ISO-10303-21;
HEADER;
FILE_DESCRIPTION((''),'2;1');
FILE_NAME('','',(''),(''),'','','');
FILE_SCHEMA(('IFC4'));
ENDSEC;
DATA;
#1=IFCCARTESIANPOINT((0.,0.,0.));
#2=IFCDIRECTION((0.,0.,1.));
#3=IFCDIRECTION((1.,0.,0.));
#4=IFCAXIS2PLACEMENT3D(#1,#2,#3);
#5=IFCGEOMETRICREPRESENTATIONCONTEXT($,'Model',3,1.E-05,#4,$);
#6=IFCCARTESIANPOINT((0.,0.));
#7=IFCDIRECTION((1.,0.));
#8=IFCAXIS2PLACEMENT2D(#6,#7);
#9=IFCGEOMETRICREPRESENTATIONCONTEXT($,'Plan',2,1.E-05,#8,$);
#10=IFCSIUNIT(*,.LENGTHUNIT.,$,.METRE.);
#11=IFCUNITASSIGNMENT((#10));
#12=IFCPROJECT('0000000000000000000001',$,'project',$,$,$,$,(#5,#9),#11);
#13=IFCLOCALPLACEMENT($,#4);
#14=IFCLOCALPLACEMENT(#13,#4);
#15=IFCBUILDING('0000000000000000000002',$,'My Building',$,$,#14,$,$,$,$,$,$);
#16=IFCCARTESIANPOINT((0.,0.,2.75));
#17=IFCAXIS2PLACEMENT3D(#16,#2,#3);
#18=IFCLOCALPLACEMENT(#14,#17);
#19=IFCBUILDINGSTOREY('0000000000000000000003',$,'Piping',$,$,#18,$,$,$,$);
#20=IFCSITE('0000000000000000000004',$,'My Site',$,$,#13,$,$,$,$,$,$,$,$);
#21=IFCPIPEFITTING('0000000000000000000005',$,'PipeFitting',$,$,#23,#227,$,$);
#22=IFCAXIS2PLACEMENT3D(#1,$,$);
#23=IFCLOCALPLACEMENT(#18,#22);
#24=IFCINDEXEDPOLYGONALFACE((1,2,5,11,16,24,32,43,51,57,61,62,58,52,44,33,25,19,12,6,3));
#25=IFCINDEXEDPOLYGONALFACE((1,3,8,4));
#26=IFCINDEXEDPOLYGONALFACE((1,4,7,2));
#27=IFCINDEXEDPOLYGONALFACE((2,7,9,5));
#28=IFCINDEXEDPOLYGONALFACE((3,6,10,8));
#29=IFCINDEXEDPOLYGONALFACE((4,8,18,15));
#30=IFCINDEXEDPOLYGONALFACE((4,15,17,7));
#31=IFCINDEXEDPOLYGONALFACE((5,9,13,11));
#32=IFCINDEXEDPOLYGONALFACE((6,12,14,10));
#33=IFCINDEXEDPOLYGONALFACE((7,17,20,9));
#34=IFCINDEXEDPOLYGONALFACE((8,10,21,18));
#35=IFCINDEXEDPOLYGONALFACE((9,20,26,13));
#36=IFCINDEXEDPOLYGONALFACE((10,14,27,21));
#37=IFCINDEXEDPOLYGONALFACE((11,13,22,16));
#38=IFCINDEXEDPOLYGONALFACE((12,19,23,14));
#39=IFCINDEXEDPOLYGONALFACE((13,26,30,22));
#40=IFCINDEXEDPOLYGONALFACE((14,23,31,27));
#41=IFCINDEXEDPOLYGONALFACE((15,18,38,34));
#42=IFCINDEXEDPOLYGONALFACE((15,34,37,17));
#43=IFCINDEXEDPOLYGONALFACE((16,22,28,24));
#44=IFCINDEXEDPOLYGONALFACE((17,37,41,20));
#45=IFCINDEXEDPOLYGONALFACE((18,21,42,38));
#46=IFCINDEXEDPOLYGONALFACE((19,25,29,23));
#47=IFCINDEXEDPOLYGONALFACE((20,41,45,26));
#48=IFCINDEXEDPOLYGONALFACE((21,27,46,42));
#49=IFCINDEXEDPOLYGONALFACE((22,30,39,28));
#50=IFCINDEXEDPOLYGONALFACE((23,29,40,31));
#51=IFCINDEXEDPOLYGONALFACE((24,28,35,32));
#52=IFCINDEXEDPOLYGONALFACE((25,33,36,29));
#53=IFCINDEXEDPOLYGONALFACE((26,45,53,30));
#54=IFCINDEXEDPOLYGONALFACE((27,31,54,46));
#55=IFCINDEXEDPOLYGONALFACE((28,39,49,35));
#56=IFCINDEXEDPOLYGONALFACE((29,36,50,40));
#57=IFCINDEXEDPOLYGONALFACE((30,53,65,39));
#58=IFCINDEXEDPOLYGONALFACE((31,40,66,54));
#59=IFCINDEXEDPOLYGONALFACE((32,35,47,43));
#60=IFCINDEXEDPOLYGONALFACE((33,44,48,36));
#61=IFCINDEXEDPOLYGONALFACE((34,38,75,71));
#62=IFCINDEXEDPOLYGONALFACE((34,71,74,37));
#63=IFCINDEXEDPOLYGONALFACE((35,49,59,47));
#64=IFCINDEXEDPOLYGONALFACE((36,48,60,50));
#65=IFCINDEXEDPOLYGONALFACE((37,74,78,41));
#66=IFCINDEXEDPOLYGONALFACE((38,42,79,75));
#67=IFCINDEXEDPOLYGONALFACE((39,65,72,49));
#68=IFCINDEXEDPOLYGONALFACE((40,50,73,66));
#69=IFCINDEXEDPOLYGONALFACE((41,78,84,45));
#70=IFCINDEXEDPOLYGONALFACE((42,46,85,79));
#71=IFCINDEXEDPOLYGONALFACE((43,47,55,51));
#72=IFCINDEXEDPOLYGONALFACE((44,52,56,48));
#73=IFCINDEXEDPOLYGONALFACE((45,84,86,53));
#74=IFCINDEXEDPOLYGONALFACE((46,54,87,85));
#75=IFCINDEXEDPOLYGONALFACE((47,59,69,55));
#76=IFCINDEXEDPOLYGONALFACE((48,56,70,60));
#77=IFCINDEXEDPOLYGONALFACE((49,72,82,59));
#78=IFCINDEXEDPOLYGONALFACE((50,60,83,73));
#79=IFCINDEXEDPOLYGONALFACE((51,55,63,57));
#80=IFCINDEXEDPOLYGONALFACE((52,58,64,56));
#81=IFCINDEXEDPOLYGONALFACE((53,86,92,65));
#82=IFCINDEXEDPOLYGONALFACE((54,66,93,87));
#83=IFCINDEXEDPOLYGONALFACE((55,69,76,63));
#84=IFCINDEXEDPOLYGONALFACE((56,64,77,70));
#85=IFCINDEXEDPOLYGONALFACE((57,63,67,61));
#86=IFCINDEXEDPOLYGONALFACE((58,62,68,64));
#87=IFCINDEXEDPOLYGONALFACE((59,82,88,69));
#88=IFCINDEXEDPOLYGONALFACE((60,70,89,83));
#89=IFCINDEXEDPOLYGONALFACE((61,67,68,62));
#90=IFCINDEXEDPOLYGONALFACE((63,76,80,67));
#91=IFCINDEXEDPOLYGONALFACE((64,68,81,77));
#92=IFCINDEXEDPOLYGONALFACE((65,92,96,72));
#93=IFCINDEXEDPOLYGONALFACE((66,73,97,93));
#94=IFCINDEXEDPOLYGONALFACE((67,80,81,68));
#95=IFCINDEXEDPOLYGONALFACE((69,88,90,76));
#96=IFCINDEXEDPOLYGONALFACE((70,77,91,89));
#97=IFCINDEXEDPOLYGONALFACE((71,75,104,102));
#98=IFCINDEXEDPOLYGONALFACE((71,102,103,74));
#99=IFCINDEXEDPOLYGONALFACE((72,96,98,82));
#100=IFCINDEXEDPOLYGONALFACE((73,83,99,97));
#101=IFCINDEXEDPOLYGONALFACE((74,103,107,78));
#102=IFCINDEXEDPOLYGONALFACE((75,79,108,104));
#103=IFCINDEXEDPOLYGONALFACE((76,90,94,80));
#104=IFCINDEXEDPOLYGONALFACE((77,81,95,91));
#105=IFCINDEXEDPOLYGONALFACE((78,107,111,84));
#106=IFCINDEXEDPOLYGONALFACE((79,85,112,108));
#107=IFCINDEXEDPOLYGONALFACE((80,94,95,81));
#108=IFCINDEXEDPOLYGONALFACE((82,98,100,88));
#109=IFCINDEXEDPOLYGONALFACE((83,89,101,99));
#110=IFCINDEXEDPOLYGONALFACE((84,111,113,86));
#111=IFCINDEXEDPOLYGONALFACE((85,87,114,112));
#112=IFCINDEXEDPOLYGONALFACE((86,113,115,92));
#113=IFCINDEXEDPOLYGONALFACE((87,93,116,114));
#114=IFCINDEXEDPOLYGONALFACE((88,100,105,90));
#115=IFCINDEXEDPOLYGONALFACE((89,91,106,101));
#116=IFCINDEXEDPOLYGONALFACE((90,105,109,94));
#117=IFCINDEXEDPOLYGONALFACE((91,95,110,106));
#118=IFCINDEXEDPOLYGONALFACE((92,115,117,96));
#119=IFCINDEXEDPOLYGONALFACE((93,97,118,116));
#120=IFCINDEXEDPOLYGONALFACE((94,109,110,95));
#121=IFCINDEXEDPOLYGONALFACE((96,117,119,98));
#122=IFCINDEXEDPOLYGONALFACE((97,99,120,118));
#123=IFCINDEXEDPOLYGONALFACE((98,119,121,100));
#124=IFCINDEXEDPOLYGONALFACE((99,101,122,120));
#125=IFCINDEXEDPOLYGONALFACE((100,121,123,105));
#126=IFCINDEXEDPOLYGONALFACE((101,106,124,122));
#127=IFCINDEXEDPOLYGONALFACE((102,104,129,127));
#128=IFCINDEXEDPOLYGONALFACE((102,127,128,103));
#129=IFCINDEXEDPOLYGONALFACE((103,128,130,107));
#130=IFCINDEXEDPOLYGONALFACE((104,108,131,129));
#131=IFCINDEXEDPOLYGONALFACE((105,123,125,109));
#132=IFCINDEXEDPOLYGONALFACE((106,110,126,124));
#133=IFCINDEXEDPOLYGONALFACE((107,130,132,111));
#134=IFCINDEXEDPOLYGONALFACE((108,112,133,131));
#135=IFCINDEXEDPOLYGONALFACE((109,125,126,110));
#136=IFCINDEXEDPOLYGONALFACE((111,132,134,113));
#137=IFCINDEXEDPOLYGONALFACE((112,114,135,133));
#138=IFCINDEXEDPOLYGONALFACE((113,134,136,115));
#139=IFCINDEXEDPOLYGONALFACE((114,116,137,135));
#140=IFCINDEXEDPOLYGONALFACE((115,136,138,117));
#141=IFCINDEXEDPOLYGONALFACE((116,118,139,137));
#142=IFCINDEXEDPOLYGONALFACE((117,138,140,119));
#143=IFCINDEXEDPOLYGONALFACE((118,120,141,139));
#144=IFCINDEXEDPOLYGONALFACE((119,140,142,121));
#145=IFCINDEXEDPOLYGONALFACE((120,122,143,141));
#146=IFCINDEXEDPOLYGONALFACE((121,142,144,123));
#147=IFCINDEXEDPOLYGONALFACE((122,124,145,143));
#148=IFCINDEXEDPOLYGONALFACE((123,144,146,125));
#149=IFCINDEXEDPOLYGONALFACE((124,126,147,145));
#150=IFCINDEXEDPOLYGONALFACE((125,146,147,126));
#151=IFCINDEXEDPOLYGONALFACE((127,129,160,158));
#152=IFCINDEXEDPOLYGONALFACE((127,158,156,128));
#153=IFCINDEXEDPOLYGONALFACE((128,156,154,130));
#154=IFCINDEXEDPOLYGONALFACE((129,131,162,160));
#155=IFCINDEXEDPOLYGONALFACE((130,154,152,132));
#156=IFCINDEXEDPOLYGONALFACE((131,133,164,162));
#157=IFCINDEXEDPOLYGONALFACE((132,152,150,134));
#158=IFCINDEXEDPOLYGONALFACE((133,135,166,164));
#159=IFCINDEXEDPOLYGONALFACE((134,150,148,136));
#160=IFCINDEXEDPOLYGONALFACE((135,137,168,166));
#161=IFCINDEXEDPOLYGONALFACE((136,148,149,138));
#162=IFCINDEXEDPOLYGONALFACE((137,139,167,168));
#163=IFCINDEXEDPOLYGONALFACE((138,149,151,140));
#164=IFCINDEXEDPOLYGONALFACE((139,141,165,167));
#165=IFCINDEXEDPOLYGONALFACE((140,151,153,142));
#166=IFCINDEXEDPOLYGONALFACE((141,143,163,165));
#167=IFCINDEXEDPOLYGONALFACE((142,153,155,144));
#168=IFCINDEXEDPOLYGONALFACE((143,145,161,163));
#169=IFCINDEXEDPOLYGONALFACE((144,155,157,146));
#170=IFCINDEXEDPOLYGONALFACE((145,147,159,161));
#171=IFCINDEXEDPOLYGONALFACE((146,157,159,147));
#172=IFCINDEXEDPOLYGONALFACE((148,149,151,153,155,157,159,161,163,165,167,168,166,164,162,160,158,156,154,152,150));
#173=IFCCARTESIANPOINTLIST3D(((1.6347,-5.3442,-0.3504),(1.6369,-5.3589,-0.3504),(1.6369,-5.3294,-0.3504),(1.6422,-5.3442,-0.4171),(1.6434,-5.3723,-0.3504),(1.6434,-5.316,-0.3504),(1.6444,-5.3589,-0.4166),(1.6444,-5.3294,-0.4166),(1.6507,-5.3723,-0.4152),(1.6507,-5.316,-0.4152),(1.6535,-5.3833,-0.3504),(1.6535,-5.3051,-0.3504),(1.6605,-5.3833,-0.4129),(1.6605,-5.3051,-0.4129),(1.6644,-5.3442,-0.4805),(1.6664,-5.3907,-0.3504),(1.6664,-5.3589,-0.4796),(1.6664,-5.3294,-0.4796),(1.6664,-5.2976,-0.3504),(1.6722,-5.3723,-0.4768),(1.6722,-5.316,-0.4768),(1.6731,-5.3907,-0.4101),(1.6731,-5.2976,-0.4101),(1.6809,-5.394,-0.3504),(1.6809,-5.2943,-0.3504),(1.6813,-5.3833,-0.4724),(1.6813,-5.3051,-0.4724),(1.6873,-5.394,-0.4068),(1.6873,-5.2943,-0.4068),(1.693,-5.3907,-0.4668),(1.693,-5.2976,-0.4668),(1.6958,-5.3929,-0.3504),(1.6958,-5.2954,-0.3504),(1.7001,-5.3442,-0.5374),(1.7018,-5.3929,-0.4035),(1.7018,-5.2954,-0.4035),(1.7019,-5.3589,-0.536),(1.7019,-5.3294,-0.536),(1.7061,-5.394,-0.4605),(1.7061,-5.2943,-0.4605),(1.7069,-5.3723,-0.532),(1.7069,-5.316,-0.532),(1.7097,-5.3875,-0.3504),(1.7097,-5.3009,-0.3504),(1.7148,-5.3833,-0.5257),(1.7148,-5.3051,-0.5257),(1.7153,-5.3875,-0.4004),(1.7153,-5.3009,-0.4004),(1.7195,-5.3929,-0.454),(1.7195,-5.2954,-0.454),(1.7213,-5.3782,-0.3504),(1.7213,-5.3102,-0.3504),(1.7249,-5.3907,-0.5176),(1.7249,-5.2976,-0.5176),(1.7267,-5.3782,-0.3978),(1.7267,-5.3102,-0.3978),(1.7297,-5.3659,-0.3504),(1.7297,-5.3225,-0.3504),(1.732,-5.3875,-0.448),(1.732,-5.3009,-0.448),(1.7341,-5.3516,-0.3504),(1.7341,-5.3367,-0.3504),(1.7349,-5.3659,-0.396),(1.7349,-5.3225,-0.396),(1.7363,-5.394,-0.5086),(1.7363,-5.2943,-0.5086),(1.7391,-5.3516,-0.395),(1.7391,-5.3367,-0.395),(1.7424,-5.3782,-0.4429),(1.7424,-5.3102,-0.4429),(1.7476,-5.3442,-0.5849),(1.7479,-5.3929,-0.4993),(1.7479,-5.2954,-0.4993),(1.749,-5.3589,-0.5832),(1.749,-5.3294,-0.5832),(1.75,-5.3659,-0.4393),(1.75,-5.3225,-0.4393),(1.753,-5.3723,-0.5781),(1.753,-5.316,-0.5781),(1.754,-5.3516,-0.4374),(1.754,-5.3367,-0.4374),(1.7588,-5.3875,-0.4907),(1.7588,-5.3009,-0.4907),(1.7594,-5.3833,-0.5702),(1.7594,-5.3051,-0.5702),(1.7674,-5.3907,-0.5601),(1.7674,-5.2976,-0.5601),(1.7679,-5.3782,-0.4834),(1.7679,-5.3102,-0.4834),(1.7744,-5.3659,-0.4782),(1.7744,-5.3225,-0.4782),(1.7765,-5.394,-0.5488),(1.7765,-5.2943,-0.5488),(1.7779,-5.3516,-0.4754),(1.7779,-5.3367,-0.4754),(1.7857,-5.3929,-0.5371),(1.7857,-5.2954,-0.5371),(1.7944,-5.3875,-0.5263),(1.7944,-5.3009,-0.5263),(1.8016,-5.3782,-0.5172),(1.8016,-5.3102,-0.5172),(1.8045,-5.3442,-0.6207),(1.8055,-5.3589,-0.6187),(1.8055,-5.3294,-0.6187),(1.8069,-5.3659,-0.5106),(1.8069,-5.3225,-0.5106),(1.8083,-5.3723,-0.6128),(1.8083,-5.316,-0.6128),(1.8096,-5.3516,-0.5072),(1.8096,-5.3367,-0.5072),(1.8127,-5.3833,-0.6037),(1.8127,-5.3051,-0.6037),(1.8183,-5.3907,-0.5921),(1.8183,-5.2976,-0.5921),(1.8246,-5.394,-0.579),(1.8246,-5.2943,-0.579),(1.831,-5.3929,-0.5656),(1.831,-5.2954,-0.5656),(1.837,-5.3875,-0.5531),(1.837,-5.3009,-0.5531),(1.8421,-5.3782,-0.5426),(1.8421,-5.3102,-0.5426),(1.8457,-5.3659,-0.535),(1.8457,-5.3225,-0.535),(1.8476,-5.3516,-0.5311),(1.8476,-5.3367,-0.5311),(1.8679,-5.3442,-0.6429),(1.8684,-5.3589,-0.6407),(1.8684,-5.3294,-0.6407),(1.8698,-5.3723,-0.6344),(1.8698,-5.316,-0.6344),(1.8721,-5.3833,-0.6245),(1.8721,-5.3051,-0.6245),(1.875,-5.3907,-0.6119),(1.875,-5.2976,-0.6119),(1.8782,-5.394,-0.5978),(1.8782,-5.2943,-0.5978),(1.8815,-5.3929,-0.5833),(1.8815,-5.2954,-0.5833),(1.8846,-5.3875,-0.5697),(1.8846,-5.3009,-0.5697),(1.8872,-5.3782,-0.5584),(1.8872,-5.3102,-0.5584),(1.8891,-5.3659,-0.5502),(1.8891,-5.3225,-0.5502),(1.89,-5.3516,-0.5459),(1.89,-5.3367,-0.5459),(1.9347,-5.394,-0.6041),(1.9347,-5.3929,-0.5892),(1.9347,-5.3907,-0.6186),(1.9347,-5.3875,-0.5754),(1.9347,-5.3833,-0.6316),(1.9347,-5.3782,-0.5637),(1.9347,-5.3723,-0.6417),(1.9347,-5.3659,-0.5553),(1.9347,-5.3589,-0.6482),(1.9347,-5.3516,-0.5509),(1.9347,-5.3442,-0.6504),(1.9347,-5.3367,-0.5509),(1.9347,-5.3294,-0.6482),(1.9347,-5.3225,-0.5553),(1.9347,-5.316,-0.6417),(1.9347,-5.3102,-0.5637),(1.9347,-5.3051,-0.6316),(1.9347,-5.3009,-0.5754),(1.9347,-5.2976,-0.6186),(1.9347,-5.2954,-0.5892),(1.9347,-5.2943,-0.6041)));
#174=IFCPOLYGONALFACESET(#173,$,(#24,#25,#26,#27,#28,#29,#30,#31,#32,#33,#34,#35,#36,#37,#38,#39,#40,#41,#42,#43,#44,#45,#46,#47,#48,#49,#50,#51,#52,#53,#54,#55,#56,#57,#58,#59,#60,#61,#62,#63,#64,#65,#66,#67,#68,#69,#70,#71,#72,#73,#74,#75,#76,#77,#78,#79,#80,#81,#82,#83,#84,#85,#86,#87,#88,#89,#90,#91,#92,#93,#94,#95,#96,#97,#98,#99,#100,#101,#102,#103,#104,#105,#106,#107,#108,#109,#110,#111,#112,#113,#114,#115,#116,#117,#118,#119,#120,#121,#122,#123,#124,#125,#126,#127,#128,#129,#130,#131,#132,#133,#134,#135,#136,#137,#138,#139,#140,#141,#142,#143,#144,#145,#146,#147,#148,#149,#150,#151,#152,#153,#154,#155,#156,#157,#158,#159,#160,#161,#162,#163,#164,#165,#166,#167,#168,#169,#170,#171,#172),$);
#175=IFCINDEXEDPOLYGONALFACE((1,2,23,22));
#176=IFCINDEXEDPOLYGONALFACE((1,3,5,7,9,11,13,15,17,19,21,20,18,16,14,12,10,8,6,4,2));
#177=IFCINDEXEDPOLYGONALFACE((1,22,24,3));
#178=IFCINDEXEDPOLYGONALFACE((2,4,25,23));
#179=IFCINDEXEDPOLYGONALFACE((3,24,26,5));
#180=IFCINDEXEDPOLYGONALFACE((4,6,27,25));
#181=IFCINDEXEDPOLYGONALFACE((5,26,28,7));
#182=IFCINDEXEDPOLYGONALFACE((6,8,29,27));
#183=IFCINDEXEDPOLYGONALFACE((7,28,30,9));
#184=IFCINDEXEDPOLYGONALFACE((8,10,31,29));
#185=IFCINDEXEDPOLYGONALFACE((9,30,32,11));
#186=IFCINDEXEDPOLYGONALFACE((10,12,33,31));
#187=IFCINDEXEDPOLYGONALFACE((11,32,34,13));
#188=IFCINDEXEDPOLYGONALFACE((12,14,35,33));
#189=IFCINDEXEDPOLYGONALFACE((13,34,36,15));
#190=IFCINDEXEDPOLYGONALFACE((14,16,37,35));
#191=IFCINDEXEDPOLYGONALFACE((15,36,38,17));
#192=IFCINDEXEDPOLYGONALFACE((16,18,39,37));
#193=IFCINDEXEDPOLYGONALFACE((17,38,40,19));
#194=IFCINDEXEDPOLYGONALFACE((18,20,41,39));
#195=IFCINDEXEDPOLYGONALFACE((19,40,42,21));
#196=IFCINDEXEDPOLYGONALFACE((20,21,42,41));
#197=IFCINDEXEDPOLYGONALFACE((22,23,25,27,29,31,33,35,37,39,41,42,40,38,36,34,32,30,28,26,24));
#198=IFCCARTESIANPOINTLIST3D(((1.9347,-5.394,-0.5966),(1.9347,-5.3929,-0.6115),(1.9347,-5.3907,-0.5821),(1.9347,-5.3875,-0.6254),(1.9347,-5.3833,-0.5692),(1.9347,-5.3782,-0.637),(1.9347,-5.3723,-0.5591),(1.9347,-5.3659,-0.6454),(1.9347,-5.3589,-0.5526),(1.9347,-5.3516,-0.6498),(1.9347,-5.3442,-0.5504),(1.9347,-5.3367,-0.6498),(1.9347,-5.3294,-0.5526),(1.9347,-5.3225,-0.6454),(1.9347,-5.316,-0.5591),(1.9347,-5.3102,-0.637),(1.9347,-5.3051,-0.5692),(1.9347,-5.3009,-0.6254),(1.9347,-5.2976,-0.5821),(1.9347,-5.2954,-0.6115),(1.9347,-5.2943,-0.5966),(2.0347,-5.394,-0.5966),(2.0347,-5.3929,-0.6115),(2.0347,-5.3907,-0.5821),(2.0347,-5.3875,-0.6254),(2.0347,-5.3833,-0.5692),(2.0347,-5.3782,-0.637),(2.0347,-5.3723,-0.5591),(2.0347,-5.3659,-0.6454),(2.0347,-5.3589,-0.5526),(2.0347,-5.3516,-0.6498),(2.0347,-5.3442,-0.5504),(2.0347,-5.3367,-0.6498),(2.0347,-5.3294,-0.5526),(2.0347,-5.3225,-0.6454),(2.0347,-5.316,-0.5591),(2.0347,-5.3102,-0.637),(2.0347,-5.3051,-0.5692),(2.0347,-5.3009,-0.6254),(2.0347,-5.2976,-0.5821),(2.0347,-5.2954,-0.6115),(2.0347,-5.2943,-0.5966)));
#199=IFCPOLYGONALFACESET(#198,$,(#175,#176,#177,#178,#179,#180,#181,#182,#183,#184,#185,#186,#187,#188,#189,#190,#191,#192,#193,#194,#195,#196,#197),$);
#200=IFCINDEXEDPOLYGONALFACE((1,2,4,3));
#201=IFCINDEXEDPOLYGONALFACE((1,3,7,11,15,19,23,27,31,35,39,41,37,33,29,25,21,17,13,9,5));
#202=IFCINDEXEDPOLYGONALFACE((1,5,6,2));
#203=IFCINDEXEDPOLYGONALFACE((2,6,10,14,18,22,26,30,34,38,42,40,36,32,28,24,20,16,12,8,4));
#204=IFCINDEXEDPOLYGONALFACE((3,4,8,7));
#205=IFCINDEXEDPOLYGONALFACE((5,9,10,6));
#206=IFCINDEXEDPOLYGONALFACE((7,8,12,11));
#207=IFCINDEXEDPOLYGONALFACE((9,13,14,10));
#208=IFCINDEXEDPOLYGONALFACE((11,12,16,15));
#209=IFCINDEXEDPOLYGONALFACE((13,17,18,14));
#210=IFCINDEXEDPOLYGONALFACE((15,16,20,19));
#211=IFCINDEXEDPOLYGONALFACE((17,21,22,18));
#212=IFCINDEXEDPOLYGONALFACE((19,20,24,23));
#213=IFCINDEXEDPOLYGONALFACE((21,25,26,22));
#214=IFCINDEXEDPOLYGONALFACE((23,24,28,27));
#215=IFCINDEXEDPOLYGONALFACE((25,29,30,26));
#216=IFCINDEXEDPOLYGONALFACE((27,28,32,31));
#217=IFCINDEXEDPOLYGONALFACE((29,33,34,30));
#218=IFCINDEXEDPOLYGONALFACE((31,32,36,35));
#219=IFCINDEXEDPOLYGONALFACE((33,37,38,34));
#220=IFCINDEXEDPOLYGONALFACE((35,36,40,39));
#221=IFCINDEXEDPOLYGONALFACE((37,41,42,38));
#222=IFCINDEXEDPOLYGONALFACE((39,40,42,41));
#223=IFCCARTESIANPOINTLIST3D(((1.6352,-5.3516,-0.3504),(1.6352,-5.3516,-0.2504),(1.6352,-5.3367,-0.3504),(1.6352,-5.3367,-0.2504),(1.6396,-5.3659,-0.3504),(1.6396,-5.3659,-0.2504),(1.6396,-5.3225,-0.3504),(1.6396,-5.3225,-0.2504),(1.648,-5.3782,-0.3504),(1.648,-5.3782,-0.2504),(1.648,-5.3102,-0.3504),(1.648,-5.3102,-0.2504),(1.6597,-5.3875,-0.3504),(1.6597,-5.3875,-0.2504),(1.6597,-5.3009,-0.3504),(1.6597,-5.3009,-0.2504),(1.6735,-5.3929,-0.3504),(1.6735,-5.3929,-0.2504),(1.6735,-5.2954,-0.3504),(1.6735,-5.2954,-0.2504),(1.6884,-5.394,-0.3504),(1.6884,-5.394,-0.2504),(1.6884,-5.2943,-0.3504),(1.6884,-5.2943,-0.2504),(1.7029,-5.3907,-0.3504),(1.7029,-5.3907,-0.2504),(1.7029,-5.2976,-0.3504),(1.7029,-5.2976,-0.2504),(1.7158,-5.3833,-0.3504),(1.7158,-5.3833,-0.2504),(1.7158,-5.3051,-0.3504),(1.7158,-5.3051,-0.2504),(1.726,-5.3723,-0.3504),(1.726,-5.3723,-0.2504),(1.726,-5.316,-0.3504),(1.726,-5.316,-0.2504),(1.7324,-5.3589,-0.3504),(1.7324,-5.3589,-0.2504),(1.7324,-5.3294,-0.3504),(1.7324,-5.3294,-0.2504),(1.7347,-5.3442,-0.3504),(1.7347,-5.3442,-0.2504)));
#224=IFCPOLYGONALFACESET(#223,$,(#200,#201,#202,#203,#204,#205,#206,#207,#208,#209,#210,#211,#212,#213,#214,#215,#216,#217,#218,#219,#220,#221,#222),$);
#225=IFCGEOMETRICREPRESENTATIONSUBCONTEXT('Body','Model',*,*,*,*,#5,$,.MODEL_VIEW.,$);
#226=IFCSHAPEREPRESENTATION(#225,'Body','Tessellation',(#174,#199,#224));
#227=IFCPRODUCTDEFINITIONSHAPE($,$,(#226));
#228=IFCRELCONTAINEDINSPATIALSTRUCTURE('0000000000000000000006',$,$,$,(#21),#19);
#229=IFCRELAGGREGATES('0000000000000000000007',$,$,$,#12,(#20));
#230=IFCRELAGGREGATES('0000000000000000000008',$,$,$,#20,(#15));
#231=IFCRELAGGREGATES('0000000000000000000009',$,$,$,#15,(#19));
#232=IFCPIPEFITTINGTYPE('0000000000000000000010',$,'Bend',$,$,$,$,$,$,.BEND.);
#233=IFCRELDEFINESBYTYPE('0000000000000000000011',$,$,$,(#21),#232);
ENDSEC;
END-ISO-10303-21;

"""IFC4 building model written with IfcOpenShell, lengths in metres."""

from ifc_helpers import new_model, entity, si_unit, frame, origin_with_axes, origin_2d_with_axis, place, context, subcontext, project, spatial, circle, extrude, source, transform, mapped, type_object, type_shapes, element, save


model = new_model("IFC4")

# Units and contexts
model_context = context("Model", 3, precision=1e-05, world=origin_with_axes())
plan_context = context("Plan", 2, precision=1e-05, world=origin_2d_with_axis())
body_context = subcontext(model_context, "Body", "Model", "MODEL_VIEW")
ifc_project = project(units=[si_unit("LENGTHUNIT", "METRE")], contexts=[model_context, plan_context])

# Site, building, storey
site_placement = place(None, origin_with_axes())
site = spatial("IfcSite", under=ifc_project, at=site_placement, Name="My Site")
building_placement = place(site_placement, origin_with_axes())
building = spatial("IfcBuilding", under=site, at=building_placement, Name="My Building")
storey_placement = place(building_placement, frame((0.0, 0.0, 2.75), z_axis=(0.0, 0.0, 1.0), x_axis=(1.0, 0.0, 0.0)))
storey = spatial("IfcBuildingStorey", under=building, at=storey_placement, Name="Piping")

# Pipe fitting
pipe_fitting_type = type_object("IfcPipeFittingType", Name="Bend", PredefinedType="BEND")
shared_shape = source(origin_with_axes(), body_context, "Body", "SolidModel", [
    entity("IfcSweptDiskSolid", entity("IfcIndexedPolyCurve", entity("IfcCartesianPointList3D", [[0.0, 0.0, -0.1], [0.0732, 0.0, -0.2768], [0.25, 0.0, -0.35]]), [entity("IfcArcIndex", [1, 2, 3])]), 0.05),
    extrude(circle(Radius=0.05), origin_with_axes(), (0.0, 0.0, -1.0), 0.1),
    extrude(circle(Radius=0.05), frame((0.25, 0.0, -0.35), z_axis=(1.0, 0.0, 0.0), x_axis=(0.0, 0.0, 1.0)), (0.0, 0.0, 1.0), 0.1),
])
type_shapes(pipe_fitting_type, [shared_shape])
for number, where, z_axis, x_axis, name in (
    (1, (2.0347, -5.3442, -0.6004), (1.0, 0.0, 0.0), (0.0, 0.0, 1.0), "PipeFitting"),
):
    element("IfcPipeFitting", number, at=place(storey_placement, frame(where, z_axis=z_axis, x_axis=x_axis)), inside=storey, type_object=pipe_fitting_type, Name=name, context=body_context, shape_type="MappedRepresentation", body=[
        mapped(shared_shape, transform((0.0, 0.0, 0.0), x_axis=(1.0, 0.0, 0.0), y_axis=(0.0, 1.0, 0.0), z_axis=(0.0, 0.0, 1.0), scale=1.0)),
    ])

save(model, "model.ifc")
